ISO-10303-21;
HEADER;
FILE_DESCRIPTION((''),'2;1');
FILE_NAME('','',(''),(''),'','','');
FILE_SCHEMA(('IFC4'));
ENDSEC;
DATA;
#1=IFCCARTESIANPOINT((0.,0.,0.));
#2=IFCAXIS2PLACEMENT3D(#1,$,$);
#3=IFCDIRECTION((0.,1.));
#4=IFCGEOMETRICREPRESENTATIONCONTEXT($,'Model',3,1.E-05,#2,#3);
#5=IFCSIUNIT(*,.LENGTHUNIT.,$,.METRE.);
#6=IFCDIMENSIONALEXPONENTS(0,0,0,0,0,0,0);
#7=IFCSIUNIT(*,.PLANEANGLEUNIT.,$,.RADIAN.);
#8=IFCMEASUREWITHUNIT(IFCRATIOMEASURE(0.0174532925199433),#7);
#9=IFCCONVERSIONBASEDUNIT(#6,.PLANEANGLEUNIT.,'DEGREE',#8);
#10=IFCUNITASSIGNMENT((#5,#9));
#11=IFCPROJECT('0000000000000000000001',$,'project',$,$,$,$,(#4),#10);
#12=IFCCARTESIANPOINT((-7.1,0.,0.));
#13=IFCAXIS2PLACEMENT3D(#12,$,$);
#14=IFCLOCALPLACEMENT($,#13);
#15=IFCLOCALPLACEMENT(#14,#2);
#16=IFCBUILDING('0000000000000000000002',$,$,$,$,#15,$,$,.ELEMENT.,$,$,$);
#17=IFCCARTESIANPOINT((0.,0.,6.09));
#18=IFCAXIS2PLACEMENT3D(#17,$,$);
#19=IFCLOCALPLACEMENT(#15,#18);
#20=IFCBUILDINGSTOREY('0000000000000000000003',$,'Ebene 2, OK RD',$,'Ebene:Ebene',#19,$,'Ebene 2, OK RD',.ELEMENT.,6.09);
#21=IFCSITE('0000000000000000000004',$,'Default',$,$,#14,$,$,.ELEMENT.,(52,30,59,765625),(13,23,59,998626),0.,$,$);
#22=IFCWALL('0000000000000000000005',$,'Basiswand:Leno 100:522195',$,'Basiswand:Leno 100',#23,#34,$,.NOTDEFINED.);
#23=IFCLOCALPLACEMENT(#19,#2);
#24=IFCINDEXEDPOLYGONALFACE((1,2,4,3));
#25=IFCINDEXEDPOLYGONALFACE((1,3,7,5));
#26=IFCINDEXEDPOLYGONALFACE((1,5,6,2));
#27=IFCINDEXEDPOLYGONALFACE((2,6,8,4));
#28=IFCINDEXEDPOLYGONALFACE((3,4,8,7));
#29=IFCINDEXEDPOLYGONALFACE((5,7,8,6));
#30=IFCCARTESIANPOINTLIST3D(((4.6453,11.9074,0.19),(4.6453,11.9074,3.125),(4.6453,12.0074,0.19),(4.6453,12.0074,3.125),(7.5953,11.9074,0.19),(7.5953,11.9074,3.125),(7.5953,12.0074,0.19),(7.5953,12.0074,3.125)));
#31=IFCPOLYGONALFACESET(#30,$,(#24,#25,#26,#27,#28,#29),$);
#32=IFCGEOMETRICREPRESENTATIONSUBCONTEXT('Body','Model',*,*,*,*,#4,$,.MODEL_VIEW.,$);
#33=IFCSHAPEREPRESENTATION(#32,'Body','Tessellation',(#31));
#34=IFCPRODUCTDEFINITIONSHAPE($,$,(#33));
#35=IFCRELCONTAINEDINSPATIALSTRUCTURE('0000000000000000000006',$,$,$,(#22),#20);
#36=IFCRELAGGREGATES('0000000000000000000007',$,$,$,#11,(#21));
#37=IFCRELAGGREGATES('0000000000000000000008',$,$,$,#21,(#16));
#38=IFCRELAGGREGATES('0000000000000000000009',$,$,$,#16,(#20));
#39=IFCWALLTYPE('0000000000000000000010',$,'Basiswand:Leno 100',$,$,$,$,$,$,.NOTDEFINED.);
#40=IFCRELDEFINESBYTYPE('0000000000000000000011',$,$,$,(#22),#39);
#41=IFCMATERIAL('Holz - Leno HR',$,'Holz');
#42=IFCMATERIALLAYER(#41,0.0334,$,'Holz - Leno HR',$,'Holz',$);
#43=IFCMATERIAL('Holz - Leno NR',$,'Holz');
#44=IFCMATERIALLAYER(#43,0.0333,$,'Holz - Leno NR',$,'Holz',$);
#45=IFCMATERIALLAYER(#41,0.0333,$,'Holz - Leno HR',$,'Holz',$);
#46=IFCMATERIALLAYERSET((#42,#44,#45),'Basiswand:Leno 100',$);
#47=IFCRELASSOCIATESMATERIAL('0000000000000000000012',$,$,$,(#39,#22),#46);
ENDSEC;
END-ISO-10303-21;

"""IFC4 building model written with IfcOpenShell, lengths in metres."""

from ifc_helpers import new_model, entity, si_unit, converted_unit, direction, frame, origin, place, context, subcontext, project, spatial, indexed_curve, outline, extrude, material, layer, layer_set, type_object, element, save


model = new_model("IFC4")

# Units and contexts
model_context = context("Model", 3, precision=1e-05, world=origin(), true_north=direction((0.0, 1.0)))
body_context = subcontext(model_context, "Body", "Model", "MODEL_VIEW")
ifc_project = project(units=[si_unit("LENGTHUNIT", "METRE"), converted_unit("PLANEANGLEUNIT", "DEGREE", entity("IfcRatioMeasure", 0.0174532925199433), si_unit("PLANEANGLEUNIT", "RADIAN"), dimensions=[0, 0, 0, 0, 0, 0, 0])], contexts=[model_context])

# Site, building, storey
site_placement = place(None, frame((-7.1, 0.0, 0.0)))
site = spatial("IfcSite", under=ifc_project, at=site_placement, Name="Default", CompositionType="ELEMENT", RefLatitude=(52, 30, 59, 765625), RefLongitude=(13, 23, 59, 998626), RefElevation=0.0)
building_placement = place(site_placement, origin())
building = spatial("IfcBuilding", under=site, at=building_placement, CompositionType="ELEMENT")
storey_placement = place(building_placement, frame((0.0, 0.0, 6.09)))
storey = spatial("IfcBuildingStorey", under=building, at=storey_placement, Name="Ebene 2, OK RD", ObjectType="Ebene:Ebene", LongName="Ebene 2, OK RD", CompositionType="ELEMENT", Elevation=6.09)

# Shared definitions
ifc_material_1 = material(Name="Holz - Leno HR", Category="Holz")
ifc_material_2 = material(Name="Holz - Leno NR", Category="Holz")

# Wall
ifc_layer_1 = layer(ifc_material_1, 0.0334, Name="Holz - Leno HR", Category="Holz")
ifc_layer_2 = layer(ifc_material_2, 0.0333, Name="Holz - Leno NR", Category="Holz")
ifc_layer_3 = layer(ifc_material_1, 0.0333, Name="Holz - Leno HR", Category="Holz")
ifc_layer_set_1 = layer_set([ifc_layer_1, ifc_layer_2, ifc_layer_3], Name="Basiswand:Leno 100")
wall_type = type_object("IfcWallType", Name="Basiswand:Leno 100", PredefinedType="NOTDEFINED", material=ifc_layer_set_1)
wall_1_placement = place(storey_placement, frame((7.5953, 11.9574, 0.19), z_axis=(0.0, 0.0, 1.0), x_axis=(-1.0, 0.0, 0.0)))
element("IfcWall", 1, at=wall_1_placement, inside=storey, type_object=wall_type, material=ifc_layer_set_1, Name="Basiswand:Leno 100:522195", ObjectType="Basiswand:Leno 100", PredefinedType="NOTDEFINED", context=body_context, shape_type="SweptSolid", body=[
    extrude(outline(indexed_curve([(2.95, 0.05), (0.0, 0.05), (0.0, -0.05), (2.95, -0.05), (2.95, 0.05)], self_intersect=False)), origin(), (0.0, 0.0, 1.0), 2.935),
])

save(model, "model.ifc")
